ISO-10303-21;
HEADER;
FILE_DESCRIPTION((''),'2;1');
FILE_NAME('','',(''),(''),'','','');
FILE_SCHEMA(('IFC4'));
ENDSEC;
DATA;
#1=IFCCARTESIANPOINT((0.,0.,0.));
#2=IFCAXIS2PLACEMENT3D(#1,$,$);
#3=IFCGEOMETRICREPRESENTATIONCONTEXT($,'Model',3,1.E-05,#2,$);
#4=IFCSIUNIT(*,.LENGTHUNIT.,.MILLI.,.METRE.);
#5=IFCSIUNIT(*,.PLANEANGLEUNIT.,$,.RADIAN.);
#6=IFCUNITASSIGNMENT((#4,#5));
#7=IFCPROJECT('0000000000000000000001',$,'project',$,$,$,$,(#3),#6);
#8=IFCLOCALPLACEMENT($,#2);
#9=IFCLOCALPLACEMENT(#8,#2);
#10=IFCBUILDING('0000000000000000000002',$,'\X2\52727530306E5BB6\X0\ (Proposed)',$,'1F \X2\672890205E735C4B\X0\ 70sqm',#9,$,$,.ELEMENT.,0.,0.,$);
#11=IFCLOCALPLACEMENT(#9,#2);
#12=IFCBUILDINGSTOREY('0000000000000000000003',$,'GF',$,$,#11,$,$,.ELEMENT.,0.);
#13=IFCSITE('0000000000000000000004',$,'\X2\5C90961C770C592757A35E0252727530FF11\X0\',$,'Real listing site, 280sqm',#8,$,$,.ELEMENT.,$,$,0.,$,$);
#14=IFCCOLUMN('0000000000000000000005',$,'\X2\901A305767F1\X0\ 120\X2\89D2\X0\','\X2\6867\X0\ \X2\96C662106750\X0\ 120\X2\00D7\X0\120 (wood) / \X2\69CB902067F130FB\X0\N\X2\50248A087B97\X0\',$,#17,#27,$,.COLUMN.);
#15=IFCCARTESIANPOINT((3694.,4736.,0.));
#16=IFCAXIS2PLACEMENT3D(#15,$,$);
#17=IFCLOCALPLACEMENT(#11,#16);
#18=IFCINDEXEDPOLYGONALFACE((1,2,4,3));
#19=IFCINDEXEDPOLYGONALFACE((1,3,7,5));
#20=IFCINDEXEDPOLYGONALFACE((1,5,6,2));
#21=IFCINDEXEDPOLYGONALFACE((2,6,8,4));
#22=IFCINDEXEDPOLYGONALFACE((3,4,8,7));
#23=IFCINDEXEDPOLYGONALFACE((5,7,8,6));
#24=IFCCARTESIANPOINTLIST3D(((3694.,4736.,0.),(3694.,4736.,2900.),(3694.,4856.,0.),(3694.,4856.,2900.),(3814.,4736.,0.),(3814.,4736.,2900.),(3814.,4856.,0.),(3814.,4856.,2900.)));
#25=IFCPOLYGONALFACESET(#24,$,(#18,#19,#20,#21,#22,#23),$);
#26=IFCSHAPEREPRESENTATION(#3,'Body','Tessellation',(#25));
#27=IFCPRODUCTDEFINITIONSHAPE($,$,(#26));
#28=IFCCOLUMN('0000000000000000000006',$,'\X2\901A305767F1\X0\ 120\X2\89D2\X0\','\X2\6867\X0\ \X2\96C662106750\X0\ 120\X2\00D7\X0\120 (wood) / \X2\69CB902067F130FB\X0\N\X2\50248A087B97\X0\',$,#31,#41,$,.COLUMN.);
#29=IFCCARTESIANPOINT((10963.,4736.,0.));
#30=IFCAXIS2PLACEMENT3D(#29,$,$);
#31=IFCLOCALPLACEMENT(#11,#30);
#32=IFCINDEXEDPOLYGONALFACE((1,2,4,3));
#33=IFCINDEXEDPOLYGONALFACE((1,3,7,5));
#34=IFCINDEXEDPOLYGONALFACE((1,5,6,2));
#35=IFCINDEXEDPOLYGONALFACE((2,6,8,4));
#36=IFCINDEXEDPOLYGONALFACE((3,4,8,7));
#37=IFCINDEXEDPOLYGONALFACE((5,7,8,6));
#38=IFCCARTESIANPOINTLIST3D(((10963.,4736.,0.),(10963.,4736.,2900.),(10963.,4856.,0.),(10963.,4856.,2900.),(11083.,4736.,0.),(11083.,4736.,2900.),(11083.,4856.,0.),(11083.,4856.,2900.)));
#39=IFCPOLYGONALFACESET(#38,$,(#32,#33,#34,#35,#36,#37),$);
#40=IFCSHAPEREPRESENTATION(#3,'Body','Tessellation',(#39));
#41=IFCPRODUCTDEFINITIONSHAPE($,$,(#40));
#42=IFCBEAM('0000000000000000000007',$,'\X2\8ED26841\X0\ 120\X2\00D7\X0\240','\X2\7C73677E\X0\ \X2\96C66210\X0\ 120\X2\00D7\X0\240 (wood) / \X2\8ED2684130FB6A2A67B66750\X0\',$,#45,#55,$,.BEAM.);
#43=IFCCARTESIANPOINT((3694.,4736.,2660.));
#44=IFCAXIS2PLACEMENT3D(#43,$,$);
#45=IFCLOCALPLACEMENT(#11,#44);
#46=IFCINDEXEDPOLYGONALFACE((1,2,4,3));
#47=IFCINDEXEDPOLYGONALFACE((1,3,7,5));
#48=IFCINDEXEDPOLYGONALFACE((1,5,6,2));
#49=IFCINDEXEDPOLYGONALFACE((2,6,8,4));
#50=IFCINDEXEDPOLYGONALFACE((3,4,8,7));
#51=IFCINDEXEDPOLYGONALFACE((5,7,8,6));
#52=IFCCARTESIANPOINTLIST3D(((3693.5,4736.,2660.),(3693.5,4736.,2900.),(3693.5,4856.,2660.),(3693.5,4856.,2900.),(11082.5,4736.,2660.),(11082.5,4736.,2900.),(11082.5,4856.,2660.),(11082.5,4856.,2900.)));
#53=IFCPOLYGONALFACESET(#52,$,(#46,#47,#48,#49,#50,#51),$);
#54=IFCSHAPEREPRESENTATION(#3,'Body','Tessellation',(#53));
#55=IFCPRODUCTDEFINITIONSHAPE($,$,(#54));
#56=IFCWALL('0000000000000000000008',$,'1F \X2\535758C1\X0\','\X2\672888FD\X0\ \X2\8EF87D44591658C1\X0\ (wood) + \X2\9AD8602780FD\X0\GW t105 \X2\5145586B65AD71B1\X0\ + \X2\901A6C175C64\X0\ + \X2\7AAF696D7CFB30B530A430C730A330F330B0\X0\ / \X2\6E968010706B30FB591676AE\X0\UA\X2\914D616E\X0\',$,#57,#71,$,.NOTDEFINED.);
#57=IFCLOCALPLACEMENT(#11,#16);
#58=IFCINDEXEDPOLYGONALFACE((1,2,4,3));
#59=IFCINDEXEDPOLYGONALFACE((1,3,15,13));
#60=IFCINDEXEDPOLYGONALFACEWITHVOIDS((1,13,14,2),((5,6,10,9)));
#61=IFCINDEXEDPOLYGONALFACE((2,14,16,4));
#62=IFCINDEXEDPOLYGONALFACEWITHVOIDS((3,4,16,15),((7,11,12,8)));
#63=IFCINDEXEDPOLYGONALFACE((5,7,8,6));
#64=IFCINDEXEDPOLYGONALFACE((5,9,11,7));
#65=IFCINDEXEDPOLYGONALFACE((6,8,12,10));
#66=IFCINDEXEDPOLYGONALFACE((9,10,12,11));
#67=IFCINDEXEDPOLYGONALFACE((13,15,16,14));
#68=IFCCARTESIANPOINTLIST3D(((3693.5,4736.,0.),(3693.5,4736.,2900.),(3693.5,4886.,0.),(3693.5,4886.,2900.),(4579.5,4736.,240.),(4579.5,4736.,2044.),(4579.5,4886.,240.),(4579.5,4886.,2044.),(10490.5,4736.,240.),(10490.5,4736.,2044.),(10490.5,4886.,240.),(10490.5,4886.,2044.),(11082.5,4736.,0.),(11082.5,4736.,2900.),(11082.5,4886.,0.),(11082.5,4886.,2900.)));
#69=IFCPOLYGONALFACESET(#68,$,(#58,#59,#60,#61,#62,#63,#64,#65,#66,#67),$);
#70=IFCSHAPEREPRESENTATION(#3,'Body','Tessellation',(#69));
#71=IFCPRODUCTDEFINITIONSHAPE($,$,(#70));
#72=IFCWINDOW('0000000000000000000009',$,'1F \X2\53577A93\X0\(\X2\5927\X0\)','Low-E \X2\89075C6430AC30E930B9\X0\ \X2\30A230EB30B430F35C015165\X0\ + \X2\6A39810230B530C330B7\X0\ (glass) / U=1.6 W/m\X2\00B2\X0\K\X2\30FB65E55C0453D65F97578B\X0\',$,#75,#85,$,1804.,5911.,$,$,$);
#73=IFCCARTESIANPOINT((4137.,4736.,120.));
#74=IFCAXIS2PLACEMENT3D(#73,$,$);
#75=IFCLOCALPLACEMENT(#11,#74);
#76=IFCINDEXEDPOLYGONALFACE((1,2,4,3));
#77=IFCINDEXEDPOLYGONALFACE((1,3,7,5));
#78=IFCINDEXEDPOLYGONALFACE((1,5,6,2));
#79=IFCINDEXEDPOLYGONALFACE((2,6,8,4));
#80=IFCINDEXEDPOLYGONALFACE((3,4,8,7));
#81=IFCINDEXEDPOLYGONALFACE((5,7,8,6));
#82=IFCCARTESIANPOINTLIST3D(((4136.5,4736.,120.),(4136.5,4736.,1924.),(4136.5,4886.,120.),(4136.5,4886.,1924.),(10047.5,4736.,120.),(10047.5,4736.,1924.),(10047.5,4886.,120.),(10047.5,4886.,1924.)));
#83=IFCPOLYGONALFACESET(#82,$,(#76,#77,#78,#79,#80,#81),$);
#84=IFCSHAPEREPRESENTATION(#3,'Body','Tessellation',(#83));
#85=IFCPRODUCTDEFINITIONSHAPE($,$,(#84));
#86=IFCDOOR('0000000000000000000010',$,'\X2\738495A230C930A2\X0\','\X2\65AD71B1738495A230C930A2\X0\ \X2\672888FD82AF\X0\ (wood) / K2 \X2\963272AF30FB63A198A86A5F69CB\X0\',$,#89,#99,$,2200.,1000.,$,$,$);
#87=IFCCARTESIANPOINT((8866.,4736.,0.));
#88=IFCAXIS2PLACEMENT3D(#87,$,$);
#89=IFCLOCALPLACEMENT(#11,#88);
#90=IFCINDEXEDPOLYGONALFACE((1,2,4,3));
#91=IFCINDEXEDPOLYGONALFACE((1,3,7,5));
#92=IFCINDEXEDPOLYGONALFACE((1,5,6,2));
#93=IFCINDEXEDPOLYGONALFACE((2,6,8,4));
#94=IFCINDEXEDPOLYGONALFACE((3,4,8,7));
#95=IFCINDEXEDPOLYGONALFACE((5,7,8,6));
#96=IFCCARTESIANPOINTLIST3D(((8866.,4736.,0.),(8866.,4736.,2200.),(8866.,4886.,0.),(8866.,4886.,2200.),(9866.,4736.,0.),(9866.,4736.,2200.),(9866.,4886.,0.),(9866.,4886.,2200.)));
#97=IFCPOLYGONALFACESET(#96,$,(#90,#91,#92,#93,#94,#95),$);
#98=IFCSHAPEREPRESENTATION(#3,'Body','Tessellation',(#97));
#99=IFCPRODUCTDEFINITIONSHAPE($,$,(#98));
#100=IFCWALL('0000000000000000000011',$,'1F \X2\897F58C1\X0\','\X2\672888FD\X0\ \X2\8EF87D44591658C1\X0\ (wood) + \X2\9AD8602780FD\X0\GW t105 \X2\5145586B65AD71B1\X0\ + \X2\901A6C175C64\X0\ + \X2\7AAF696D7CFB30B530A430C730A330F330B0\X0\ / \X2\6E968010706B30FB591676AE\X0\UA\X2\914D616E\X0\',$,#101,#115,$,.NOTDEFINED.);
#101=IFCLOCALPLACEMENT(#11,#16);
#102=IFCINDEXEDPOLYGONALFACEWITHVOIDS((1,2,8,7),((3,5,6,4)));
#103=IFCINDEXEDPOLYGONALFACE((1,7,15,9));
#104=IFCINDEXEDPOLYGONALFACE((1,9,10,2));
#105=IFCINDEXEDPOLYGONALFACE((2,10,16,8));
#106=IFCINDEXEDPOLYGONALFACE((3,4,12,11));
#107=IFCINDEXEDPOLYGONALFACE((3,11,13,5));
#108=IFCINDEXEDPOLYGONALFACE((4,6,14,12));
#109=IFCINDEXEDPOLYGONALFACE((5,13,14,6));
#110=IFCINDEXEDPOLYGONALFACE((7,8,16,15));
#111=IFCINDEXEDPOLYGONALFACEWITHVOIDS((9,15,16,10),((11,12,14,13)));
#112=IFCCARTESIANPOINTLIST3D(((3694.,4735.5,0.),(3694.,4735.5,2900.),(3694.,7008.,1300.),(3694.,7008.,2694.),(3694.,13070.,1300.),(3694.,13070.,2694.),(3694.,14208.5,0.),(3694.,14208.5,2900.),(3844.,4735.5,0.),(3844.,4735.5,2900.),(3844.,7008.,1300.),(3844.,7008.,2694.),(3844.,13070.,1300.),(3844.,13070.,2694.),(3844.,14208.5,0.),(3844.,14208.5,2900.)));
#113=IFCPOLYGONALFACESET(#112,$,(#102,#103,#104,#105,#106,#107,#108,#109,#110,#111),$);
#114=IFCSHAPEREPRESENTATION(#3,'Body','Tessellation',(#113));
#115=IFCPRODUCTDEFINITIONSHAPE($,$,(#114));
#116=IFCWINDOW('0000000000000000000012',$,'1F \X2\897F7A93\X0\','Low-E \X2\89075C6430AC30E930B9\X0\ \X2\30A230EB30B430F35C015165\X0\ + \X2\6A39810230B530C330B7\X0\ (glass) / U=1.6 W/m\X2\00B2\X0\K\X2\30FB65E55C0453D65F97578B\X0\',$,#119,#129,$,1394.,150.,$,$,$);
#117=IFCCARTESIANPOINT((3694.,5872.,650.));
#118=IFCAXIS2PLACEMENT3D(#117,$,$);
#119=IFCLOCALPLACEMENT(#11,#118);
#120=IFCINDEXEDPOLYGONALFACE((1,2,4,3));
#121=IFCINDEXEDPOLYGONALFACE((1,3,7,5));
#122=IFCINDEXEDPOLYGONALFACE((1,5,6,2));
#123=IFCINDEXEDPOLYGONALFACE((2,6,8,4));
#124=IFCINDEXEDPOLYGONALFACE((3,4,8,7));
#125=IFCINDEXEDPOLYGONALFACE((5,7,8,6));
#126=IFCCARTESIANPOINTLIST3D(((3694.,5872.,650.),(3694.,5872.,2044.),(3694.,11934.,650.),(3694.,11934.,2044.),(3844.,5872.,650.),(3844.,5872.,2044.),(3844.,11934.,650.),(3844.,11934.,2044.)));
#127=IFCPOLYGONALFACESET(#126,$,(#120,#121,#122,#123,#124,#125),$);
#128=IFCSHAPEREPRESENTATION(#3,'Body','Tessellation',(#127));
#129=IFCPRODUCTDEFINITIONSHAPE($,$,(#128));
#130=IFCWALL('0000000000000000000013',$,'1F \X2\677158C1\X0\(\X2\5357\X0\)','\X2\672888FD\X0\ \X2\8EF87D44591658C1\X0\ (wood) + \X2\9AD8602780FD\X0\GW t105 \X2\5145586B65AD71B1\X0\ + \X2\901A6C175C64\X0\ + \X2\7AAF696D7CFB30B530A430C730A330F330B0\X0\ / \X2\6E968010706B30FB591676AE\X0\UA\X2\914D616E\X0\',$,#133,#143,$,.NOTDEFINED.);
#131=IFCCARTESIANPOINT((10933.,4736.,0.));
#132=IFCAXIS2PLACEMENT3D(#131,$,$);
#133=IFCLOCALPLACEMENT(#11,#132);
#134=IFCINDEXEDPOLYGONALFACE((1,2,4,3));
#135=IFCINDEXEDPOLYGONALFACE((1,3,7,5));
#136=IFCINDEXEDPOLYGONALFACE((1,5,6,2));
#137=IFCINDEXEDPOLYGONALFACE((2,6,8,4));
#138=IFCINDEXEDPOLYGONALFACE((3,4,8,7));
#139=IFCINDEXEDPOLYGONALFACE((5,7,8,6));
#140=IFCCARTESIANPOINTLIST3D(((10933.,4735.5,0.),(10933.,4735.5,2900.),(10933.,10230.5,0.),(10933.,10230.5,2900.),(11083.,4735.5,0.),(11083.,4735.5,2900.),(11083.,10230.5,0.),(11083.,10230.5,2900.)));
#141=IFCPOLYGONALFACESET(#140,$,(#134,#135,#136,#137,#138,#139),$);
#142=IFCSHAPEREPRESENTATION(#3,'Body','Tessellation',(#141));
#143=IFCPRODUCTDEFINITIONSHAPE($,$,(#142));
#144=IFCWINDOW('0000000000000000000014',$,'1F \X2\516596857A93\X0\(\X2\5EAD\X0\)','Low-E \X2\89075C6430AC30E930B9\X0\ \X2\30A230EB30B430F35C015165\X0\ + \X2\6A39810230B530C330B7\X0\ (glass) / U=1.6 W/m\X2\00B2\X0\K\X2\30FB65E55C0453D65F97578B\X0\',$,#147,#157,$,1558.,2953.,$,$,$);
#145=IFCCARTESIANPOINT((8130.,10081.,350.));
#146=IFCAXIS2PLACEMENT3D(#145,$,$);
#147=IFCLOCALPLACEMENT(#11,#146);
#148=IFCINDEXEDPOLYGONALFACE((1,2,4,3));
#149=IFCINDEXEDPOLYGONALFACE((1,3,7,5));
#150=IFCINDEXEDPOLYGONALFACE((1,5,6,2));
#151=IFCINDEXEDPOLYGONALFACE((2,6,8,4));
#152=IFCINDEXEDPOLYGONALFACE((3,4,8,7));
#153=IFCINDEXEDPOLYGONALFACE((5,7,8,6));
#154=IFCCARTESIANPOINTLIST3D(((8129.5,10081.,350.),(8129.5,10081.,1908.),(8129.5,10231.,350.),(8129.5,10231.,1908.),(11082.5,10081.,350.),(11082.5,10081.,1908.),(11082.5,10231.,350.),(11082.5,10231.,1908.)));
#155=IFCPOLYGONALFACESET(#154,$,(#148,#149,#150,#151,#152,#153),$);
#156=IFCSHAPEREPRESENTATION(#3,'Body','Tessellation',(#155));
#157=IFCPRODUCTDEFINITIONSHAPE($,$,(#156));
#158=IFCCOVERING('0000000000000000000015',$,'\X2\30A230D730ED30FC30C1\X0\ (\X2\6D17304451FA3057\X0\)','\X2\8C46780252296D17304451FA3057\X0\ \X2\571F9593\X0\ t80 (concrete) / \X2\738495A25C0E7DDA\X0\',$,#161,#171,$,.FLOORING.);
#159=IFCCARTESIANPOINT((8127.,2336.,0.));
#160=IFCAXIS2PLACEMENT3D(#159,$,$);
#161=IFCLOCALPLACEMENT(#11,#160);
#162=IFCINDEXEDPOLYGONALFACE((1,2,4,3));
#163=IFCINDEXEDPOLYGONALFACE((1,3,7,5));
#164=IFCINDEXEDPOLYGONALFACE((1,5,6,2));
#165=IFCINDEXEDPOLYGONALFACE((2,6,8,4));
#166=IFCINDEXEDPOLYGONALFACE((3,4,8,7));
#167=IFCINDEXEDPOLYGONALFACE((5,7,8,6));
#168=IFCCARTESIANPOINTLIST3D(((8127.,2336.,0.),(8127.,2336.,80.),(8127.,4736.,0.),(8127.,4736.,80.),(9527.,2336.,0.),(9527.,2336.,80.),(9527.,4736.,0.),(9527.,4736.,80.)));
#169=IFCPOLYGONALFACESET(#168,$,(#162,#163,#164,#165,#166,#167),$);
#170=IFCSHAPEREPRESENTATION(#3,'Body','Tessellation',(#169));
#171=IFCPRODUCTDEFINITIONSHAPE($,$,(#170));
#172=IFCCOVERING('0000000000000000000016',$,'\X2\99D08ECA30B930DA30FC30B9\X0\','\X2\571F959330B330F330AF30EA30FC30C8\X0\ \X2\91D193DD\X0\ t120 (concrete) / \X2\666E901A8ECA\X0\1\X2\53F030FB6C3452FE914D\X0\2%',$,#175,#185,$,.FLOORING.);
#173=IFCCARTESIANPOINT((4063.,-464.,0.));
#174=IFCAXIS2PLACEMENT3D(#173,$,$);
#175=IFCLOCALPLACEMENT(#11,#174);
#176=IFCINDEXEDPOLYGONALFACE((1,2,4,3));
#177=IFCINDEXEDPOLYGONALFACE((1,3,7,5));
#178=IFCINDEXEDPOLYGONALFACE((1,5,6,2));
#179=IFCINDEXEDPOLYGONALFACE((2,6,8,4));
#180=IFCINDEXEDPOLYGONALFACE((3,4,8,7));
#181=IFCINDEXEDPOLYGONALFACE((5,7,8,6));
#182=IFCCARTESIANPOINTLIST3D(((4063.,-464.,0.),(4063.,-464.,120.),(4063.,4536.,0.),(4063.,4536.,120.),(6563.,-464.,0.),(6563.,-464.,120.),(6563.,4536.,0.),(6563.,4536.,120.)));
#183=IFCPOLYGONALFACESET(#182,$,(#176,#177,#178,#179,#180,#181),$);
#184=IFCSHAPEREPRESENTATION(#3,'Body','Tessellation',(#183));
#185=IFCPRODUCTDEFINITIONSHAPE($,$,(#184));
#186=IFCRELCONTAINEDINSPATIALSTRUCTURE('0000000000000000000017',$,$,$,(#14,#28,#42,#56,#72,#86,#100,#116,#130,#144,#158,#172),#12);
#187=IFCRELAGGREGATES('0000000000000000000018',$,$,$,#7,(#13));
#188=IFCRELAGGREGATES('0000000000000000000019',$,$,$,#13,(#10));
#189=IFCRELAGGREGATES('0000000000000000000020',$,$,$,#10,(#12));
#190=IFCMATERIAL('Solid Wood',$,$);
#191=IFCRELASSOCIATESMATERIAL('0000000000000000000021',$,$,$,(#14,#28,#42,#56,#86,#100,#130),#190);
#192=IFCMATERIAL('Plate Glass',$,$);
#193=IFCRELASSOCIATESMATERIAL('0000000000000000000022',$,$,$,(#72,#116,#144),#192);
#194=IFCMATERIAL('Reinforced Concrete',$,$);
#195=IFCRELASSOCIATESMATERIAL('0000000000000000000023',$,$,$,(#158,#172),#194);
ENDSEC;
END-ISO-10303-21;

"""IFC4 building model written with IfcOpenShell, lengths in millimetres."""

from ifc_helpers import new_model, si_unit, frame, frame_2d, origin, place, context, project, spatial, rectangle, extrude, material, element, fill, save


model = new_model("IFC4")

# Units and contexts
model_context = context("Model", 3, precision=1e-05, world=origin())
ifc_project = project(units=[si_unit("LENGTHUNIT", "METRE", prefix="MILLI"), si_unit("PLANEANGLEUNIT", "RADIAN")], contexts=[model_context])

# Site, building, storey
site_placement = place(None, origin())
site = spatial("IfcSite", under=ifc_project, at=site_placement, Name="岐阜県大垣市割田１", ObjectType="Real listing site, 280sqm", CompositionType="ELEMENT", RefElevation=0.0)
building_placement = place(site_placement, origin())
building = spatial("IfcBuilding", under=site, at=building_placement, Name="割田の家 (Proposed)", ObjectType="1F 木造平屋 70sqm", CompositionType="ELEMENT", ElevationOfRefHeight=0.0, ElevationOfTerrain=0.0)
storey_placement = place(building_placement, origin())
storey = spatial("IfcBuildingStorey", under=building, at=storey_placement, Name="GF", CompositionType="ELEMENT", Elevation=0.0)

# Columns
ifc_material_1 = material(Name="Solid Wood")
column_1_placement = place(storey_placement, frame((3694.0, 4736.0, 0.0)))
element("IfcColumn", 1, at=column_1_placement, inside=storey, material=ifc_material_1, Name="通し柱 120角", Description="桧 集成材 120×120 (wood) / 構造柱・N値計算", PredefinedType="COLUMN", context=model_context, shape_type="SweptSolid", body=[
    extrude(rectangle(XDim=120.0, YDim=120.0, at=frame_2d((60.0, 60.0))), frame((3694.0, 4736.0, 0.0)), (0.0, 0.0, 1.0), 2900.0),
])
column_2_placement = place(storey_placement, frame((10963.0, 4736.0, 0.0)))
element("IfcColumn", 2, at=column_2_placement, inside=storey, material=ifc_material_1, Name="通し柱 120角", Description="桧 集成材 120×120 (wood) / 構造柱・N値計算", PredefinedType="COLUMN", context=model_context, shape_type="SweptSolid", body=[
    extrude(rectangle(XDim=120.0, YDim=120.0, at=frame_2d((60.0, 60.0))), frame((10963.0, 4736.0, 0.0)), (0.0, 0.0, 1.0), 2900.0),
])

# Beam
beam_1_placement = place(storey_placement, frame((3694.0, 4736.0, 2660.0)))
element("IfcBeam", 3, at=beam_1_placement, inside=storey, material=ifc_material_1, Name="軒桁 120×240", Description="米松 集成 120×240 (wood) / 軒桁・横架材", PredefinedType="BEAM", context=model_context, shape_type="SweptSolid", body=[
    extrude(rectangle(XDim=7389.0, YDim=120.0, at=frame_2d((3694.0, 60.0))), frame((3694.0, 4736.0, 2660.0)), (0.0, 0.0, 1.0), 240.0),
])

# Shared definitions
ifc_material_2 = material(Name="Reinforced Concrete")

# Wall, openings, window, door
wall_1_placement = place(storey_placement, frame((3694.0, 4736.0, 0.0)))
wall_1 = element("IfcWall", 4, at=wall_1_placement, inside=storey, material=ifc_material_1, Name="1F 南壁", Description="木製 軸組外壁 (wood) + 高性能GW t105 充填断熱 + 通気層 + 窯業系サイディング / 準耐火・外皮UA配慮", PredefinedType="NOTDEFINED", context=model_context, shape_type="SweptSolid", body=[
    extrude(rectangle(XDim=7389.0, YDim=150.0, at=frame_2d((3694.0, 75.0))), frame((3694.0, 4736.0, 0.0)), (0.0, 0.0, 1.0), 2900.0),
])
opening_1_placement = place(storey_placement, frame((4137.0, 4736.0, 120.0)))
opening_1 = element("IfcOpeningElement", 5, at=opening_1_placement, cuts=wall_1, PredefinedType="NOTDEFINED", context=model_context, shape_type="SweptSolid", body=[
    extrude(rectangle(XDim=5911.0, YDim=150.0, at=frame_2d((2955.0, 75.0))), frame((4137.0, 4736.0, 120.0)), (0.0, 0.0, 1.0), 1804.0),
])
opening_2_placement = place(storey_placement, frame((8866.0, 4736.0, 0.0)))
opening_2 = element("IfcOpeningElement", 6, at=opening_2_placement, cuts=wall_1, PredefinedType="NOTDEFINED", context=model_context, shape_type="SweptSolid", body=[
    extrude(rectangle(XDim=1000.0, YDim=150.0, at=frame_2d((500.0, 75.0))), frame((8866.0, 4736.0, 0.0)), (0.0, 0.0, 1.0), 2200.0),
])
ifc_material_3 = material(Name="Plate Glass")
window_1_placement = place(storey_placement, frame((4137.0, 4736.0, 120.0)))
window_1 = element("IfcWindow", 7, at=window_1_placement, inside=storey, material=ifc_material_3, Name="1F 南窓(大)", Description="Low-E 複層ガラス アルゴン封入 + 樹脂サッシ (glass) / U=1.6 W/m²K・日射取得型", OverallHeight=1804.0, OverallWidth=5911.0, context=model_context, shape_type="SweptSolid", body=[
    extrude(rectangle(XDim=5911.0, YDim=150.0, at=frame_2d((2955.0, 75.0))), frame((4137.0, 4736.0, 120.0)), (0.0, 0.0, 1.0), 1804.0),
])
fill(opening_1, window_1)
door_1_placement = place(storey_placement, frame((8866.0, 4736.0, 0.0)))
door_1 = element("IfcDoor", 8, at=door_1_placement, inside=storey, material=ifc_material_1, Name="玄関ドア", Description="断熱玄関ドア 木製芯 (wood) / K2 防犯・採風機構", OverallHeight=2200.0, OverallWidth=1000.0, context=model_context, shape_type="SweptSolid", body=[
    extrude(rectangle(XDim=1000.0, YDim=150.0, at=frame_2d((500.0, 75.0))), frame((8866.0, 4736.0, 0.0)), (0.0, 0.0, 1.0), 2200.0),
])
fill(opening_2, door_1)

# Walls, openings, windows
wall_2_placement = place(storey_placement, frame((3694.0, 4736.0, 0.0)))
wall_2 = element("IfcWall", 9, at=wall_2_placement, inside=storey, material=ifc_material_1, Name="1F 西壁", Description="木製 軸組外壁 (wood) + 高性能GW t105 充填断熱 + 通気層 + 窯業系サイディング / 準耐火・外皮UA配慮", PredefinedType="NOTDEFINED", context=model_context, shape_type="SweptSolid", body=[
    extrude(rectangle(XDim=150.0, YDim=9473.0, at=frame_2d((75.0, 4736.0))), frame((3694.0, 4736.0, 0.0)), (0.0, 0.0, 1.0), 2900.0),
])
opening_3_placement = place(storey_placement, frame((3694.0, 5872.0, 650.0)))
opening_3 = element("IfcOpeningElement", 10, at=opening_3_placement, cuts=wall_2, PredefinedType="NOTDEFINED", context=model_context, shape_type="SweptSolid", body=[
    extrude(rectangle(XDim=150.0, YDim=6062.0, at=frame_2d((75.0, 3031.0))), frame((3694.0, 5872.0, 650.0)), (0.0, 0.0, 1.0), 1394.0),
])
window_2_placement = place(storey_placement, frame((3694.0, 5872.0, 650.0)))
window_2 = element("IfcWindow", 11, at=window_2_placement, inside=storey, material=ifc_material_3, Name="1F 西窓", Description="Low-E 複層ガラス アルゴン封入 + 樹脂サッシ (glass) / U=1.6 W/m²K・日射取得型", OverallHeight=1394.0, OverallWidth=150.0, context=model_context, shape_type="SweptSolid", body=[
    extrude(rectangle(XDim=150.0, YDim=6062.0, at=frame_2d((75.0, 3031.0))), frame((3694.0, 5872.0, 650.0)), (0.0, 0.0, 1.0), 1394.0),
])
fill(opening_3, window_2)
wall_3_placement = place(storey_placement, frame((10933.0, 4736.0, 0.0)))
wall_3 = element("IfcWall", 12, at=wall_3_placement, inside=storey, material=ifc_material_1, Name="1F 東壁(南)", Description="木製 軸組外壁 (wood) + 高性能GW t105 充填断熱 + 通気層 + 窯業系サイディング / 準耐火・外皮UA配慮", PredefinedType="NOTDEFINED", context=model_context, shape_type="SweptSolid", body=[
    extrude(rectangle(XDim=150.0, YDim=5495.0, at=frame_2d((75.0, 2747.0))), frame((10933.0, 4736.0, 0.0)), (0.0, 0.0, 1.0), 2900.0),
])
opening_4_placement = place(storey_placement, frame((8130.0, 10081.0, 350.0)))
opening_4 = element("IfcOpeningElement", 13, at=opening_4_placement, cuts=wall_3, PredefinedType="NOTDEFINED", context=model_context, shape_type="SweptSolid", body=[
    extrude(rectangle(XDim=2953.0, YDim=150.0, at=frame_2d((1476.0, 75.0))), frame((8130.0, 10081.0, 350.0)), (0.0, 0.0, 1.0), 1558.0),
])
window_3_placement = place(storey_placement, frame((8130.0, 10081.0, 350.0)))
window_3 = element("IfcWindow", 14, at=window_3_placement, inside=storey, material=ifc_material_3, Name="1F 入隅窓(庭)", Description="Low-E 複層ガラス アルゴン封入 + 樹脂サッシ (glass) / U=1.6 W/m²K・日射取得型", OverallHeight=1558.0, OverallWidth=2953.0, context=model_context, shape_type="SweptSolid", body=[
    extrude(rectangle(XDim=2953.0, YDim=150.0, at=frame_2d((1476.0, 75.0))), frame((8130.0, 10081.0, 350.0)), (0.0, 0.0, 1.0), 1558.0),
])
fill(opening_4, window_3)

# Coverings
covering_1_placement = place(storey_placement, frame((8127.0, 2336.0, 0.0)))
element("IfcCovering", 15, at=covering_1_placement, inside=storey, material=ifc_material_2, Name="アプローチ (洗い出し)", Description="豆砂利洗い出し 土間 t80 (concrete) / 玄関導線", PredefinedType="FLOORING", context=model_context, shape_type="SweptSolid", body=[
    extrude(rectangle(XDim=1400.0, YDim=2400.0, at=frame_2d((700.0, 1200.0))), frame((8127.0, 2336.0, 0.0)), (0.0, 0.0, 1.0), 80.0),
])
covering_2_placement = place(storey_placement, frame((4063.0, -464.0, 0.0)))
element("IfcCovering", 16, at=covering_2_placement, inside=storey, material=ifc_material_2, Name="駐車スペース", Description="土間コンクリート 金鏝 t120 (concrete) / 普通車1台・水勾配2%", PredefinedType="FLOORING", context=model_context, shape_type="SweptSolid", body=[
    extrude(rectangle(XDim=2500.0, YDim=5000.0, at=frame_2d((1250.0, 2500.0))), frame((4063.0, -464.0, 0.0)), (0.0, 0.0, 1.0), 120.0),
])

save(model, "model.ifc")
